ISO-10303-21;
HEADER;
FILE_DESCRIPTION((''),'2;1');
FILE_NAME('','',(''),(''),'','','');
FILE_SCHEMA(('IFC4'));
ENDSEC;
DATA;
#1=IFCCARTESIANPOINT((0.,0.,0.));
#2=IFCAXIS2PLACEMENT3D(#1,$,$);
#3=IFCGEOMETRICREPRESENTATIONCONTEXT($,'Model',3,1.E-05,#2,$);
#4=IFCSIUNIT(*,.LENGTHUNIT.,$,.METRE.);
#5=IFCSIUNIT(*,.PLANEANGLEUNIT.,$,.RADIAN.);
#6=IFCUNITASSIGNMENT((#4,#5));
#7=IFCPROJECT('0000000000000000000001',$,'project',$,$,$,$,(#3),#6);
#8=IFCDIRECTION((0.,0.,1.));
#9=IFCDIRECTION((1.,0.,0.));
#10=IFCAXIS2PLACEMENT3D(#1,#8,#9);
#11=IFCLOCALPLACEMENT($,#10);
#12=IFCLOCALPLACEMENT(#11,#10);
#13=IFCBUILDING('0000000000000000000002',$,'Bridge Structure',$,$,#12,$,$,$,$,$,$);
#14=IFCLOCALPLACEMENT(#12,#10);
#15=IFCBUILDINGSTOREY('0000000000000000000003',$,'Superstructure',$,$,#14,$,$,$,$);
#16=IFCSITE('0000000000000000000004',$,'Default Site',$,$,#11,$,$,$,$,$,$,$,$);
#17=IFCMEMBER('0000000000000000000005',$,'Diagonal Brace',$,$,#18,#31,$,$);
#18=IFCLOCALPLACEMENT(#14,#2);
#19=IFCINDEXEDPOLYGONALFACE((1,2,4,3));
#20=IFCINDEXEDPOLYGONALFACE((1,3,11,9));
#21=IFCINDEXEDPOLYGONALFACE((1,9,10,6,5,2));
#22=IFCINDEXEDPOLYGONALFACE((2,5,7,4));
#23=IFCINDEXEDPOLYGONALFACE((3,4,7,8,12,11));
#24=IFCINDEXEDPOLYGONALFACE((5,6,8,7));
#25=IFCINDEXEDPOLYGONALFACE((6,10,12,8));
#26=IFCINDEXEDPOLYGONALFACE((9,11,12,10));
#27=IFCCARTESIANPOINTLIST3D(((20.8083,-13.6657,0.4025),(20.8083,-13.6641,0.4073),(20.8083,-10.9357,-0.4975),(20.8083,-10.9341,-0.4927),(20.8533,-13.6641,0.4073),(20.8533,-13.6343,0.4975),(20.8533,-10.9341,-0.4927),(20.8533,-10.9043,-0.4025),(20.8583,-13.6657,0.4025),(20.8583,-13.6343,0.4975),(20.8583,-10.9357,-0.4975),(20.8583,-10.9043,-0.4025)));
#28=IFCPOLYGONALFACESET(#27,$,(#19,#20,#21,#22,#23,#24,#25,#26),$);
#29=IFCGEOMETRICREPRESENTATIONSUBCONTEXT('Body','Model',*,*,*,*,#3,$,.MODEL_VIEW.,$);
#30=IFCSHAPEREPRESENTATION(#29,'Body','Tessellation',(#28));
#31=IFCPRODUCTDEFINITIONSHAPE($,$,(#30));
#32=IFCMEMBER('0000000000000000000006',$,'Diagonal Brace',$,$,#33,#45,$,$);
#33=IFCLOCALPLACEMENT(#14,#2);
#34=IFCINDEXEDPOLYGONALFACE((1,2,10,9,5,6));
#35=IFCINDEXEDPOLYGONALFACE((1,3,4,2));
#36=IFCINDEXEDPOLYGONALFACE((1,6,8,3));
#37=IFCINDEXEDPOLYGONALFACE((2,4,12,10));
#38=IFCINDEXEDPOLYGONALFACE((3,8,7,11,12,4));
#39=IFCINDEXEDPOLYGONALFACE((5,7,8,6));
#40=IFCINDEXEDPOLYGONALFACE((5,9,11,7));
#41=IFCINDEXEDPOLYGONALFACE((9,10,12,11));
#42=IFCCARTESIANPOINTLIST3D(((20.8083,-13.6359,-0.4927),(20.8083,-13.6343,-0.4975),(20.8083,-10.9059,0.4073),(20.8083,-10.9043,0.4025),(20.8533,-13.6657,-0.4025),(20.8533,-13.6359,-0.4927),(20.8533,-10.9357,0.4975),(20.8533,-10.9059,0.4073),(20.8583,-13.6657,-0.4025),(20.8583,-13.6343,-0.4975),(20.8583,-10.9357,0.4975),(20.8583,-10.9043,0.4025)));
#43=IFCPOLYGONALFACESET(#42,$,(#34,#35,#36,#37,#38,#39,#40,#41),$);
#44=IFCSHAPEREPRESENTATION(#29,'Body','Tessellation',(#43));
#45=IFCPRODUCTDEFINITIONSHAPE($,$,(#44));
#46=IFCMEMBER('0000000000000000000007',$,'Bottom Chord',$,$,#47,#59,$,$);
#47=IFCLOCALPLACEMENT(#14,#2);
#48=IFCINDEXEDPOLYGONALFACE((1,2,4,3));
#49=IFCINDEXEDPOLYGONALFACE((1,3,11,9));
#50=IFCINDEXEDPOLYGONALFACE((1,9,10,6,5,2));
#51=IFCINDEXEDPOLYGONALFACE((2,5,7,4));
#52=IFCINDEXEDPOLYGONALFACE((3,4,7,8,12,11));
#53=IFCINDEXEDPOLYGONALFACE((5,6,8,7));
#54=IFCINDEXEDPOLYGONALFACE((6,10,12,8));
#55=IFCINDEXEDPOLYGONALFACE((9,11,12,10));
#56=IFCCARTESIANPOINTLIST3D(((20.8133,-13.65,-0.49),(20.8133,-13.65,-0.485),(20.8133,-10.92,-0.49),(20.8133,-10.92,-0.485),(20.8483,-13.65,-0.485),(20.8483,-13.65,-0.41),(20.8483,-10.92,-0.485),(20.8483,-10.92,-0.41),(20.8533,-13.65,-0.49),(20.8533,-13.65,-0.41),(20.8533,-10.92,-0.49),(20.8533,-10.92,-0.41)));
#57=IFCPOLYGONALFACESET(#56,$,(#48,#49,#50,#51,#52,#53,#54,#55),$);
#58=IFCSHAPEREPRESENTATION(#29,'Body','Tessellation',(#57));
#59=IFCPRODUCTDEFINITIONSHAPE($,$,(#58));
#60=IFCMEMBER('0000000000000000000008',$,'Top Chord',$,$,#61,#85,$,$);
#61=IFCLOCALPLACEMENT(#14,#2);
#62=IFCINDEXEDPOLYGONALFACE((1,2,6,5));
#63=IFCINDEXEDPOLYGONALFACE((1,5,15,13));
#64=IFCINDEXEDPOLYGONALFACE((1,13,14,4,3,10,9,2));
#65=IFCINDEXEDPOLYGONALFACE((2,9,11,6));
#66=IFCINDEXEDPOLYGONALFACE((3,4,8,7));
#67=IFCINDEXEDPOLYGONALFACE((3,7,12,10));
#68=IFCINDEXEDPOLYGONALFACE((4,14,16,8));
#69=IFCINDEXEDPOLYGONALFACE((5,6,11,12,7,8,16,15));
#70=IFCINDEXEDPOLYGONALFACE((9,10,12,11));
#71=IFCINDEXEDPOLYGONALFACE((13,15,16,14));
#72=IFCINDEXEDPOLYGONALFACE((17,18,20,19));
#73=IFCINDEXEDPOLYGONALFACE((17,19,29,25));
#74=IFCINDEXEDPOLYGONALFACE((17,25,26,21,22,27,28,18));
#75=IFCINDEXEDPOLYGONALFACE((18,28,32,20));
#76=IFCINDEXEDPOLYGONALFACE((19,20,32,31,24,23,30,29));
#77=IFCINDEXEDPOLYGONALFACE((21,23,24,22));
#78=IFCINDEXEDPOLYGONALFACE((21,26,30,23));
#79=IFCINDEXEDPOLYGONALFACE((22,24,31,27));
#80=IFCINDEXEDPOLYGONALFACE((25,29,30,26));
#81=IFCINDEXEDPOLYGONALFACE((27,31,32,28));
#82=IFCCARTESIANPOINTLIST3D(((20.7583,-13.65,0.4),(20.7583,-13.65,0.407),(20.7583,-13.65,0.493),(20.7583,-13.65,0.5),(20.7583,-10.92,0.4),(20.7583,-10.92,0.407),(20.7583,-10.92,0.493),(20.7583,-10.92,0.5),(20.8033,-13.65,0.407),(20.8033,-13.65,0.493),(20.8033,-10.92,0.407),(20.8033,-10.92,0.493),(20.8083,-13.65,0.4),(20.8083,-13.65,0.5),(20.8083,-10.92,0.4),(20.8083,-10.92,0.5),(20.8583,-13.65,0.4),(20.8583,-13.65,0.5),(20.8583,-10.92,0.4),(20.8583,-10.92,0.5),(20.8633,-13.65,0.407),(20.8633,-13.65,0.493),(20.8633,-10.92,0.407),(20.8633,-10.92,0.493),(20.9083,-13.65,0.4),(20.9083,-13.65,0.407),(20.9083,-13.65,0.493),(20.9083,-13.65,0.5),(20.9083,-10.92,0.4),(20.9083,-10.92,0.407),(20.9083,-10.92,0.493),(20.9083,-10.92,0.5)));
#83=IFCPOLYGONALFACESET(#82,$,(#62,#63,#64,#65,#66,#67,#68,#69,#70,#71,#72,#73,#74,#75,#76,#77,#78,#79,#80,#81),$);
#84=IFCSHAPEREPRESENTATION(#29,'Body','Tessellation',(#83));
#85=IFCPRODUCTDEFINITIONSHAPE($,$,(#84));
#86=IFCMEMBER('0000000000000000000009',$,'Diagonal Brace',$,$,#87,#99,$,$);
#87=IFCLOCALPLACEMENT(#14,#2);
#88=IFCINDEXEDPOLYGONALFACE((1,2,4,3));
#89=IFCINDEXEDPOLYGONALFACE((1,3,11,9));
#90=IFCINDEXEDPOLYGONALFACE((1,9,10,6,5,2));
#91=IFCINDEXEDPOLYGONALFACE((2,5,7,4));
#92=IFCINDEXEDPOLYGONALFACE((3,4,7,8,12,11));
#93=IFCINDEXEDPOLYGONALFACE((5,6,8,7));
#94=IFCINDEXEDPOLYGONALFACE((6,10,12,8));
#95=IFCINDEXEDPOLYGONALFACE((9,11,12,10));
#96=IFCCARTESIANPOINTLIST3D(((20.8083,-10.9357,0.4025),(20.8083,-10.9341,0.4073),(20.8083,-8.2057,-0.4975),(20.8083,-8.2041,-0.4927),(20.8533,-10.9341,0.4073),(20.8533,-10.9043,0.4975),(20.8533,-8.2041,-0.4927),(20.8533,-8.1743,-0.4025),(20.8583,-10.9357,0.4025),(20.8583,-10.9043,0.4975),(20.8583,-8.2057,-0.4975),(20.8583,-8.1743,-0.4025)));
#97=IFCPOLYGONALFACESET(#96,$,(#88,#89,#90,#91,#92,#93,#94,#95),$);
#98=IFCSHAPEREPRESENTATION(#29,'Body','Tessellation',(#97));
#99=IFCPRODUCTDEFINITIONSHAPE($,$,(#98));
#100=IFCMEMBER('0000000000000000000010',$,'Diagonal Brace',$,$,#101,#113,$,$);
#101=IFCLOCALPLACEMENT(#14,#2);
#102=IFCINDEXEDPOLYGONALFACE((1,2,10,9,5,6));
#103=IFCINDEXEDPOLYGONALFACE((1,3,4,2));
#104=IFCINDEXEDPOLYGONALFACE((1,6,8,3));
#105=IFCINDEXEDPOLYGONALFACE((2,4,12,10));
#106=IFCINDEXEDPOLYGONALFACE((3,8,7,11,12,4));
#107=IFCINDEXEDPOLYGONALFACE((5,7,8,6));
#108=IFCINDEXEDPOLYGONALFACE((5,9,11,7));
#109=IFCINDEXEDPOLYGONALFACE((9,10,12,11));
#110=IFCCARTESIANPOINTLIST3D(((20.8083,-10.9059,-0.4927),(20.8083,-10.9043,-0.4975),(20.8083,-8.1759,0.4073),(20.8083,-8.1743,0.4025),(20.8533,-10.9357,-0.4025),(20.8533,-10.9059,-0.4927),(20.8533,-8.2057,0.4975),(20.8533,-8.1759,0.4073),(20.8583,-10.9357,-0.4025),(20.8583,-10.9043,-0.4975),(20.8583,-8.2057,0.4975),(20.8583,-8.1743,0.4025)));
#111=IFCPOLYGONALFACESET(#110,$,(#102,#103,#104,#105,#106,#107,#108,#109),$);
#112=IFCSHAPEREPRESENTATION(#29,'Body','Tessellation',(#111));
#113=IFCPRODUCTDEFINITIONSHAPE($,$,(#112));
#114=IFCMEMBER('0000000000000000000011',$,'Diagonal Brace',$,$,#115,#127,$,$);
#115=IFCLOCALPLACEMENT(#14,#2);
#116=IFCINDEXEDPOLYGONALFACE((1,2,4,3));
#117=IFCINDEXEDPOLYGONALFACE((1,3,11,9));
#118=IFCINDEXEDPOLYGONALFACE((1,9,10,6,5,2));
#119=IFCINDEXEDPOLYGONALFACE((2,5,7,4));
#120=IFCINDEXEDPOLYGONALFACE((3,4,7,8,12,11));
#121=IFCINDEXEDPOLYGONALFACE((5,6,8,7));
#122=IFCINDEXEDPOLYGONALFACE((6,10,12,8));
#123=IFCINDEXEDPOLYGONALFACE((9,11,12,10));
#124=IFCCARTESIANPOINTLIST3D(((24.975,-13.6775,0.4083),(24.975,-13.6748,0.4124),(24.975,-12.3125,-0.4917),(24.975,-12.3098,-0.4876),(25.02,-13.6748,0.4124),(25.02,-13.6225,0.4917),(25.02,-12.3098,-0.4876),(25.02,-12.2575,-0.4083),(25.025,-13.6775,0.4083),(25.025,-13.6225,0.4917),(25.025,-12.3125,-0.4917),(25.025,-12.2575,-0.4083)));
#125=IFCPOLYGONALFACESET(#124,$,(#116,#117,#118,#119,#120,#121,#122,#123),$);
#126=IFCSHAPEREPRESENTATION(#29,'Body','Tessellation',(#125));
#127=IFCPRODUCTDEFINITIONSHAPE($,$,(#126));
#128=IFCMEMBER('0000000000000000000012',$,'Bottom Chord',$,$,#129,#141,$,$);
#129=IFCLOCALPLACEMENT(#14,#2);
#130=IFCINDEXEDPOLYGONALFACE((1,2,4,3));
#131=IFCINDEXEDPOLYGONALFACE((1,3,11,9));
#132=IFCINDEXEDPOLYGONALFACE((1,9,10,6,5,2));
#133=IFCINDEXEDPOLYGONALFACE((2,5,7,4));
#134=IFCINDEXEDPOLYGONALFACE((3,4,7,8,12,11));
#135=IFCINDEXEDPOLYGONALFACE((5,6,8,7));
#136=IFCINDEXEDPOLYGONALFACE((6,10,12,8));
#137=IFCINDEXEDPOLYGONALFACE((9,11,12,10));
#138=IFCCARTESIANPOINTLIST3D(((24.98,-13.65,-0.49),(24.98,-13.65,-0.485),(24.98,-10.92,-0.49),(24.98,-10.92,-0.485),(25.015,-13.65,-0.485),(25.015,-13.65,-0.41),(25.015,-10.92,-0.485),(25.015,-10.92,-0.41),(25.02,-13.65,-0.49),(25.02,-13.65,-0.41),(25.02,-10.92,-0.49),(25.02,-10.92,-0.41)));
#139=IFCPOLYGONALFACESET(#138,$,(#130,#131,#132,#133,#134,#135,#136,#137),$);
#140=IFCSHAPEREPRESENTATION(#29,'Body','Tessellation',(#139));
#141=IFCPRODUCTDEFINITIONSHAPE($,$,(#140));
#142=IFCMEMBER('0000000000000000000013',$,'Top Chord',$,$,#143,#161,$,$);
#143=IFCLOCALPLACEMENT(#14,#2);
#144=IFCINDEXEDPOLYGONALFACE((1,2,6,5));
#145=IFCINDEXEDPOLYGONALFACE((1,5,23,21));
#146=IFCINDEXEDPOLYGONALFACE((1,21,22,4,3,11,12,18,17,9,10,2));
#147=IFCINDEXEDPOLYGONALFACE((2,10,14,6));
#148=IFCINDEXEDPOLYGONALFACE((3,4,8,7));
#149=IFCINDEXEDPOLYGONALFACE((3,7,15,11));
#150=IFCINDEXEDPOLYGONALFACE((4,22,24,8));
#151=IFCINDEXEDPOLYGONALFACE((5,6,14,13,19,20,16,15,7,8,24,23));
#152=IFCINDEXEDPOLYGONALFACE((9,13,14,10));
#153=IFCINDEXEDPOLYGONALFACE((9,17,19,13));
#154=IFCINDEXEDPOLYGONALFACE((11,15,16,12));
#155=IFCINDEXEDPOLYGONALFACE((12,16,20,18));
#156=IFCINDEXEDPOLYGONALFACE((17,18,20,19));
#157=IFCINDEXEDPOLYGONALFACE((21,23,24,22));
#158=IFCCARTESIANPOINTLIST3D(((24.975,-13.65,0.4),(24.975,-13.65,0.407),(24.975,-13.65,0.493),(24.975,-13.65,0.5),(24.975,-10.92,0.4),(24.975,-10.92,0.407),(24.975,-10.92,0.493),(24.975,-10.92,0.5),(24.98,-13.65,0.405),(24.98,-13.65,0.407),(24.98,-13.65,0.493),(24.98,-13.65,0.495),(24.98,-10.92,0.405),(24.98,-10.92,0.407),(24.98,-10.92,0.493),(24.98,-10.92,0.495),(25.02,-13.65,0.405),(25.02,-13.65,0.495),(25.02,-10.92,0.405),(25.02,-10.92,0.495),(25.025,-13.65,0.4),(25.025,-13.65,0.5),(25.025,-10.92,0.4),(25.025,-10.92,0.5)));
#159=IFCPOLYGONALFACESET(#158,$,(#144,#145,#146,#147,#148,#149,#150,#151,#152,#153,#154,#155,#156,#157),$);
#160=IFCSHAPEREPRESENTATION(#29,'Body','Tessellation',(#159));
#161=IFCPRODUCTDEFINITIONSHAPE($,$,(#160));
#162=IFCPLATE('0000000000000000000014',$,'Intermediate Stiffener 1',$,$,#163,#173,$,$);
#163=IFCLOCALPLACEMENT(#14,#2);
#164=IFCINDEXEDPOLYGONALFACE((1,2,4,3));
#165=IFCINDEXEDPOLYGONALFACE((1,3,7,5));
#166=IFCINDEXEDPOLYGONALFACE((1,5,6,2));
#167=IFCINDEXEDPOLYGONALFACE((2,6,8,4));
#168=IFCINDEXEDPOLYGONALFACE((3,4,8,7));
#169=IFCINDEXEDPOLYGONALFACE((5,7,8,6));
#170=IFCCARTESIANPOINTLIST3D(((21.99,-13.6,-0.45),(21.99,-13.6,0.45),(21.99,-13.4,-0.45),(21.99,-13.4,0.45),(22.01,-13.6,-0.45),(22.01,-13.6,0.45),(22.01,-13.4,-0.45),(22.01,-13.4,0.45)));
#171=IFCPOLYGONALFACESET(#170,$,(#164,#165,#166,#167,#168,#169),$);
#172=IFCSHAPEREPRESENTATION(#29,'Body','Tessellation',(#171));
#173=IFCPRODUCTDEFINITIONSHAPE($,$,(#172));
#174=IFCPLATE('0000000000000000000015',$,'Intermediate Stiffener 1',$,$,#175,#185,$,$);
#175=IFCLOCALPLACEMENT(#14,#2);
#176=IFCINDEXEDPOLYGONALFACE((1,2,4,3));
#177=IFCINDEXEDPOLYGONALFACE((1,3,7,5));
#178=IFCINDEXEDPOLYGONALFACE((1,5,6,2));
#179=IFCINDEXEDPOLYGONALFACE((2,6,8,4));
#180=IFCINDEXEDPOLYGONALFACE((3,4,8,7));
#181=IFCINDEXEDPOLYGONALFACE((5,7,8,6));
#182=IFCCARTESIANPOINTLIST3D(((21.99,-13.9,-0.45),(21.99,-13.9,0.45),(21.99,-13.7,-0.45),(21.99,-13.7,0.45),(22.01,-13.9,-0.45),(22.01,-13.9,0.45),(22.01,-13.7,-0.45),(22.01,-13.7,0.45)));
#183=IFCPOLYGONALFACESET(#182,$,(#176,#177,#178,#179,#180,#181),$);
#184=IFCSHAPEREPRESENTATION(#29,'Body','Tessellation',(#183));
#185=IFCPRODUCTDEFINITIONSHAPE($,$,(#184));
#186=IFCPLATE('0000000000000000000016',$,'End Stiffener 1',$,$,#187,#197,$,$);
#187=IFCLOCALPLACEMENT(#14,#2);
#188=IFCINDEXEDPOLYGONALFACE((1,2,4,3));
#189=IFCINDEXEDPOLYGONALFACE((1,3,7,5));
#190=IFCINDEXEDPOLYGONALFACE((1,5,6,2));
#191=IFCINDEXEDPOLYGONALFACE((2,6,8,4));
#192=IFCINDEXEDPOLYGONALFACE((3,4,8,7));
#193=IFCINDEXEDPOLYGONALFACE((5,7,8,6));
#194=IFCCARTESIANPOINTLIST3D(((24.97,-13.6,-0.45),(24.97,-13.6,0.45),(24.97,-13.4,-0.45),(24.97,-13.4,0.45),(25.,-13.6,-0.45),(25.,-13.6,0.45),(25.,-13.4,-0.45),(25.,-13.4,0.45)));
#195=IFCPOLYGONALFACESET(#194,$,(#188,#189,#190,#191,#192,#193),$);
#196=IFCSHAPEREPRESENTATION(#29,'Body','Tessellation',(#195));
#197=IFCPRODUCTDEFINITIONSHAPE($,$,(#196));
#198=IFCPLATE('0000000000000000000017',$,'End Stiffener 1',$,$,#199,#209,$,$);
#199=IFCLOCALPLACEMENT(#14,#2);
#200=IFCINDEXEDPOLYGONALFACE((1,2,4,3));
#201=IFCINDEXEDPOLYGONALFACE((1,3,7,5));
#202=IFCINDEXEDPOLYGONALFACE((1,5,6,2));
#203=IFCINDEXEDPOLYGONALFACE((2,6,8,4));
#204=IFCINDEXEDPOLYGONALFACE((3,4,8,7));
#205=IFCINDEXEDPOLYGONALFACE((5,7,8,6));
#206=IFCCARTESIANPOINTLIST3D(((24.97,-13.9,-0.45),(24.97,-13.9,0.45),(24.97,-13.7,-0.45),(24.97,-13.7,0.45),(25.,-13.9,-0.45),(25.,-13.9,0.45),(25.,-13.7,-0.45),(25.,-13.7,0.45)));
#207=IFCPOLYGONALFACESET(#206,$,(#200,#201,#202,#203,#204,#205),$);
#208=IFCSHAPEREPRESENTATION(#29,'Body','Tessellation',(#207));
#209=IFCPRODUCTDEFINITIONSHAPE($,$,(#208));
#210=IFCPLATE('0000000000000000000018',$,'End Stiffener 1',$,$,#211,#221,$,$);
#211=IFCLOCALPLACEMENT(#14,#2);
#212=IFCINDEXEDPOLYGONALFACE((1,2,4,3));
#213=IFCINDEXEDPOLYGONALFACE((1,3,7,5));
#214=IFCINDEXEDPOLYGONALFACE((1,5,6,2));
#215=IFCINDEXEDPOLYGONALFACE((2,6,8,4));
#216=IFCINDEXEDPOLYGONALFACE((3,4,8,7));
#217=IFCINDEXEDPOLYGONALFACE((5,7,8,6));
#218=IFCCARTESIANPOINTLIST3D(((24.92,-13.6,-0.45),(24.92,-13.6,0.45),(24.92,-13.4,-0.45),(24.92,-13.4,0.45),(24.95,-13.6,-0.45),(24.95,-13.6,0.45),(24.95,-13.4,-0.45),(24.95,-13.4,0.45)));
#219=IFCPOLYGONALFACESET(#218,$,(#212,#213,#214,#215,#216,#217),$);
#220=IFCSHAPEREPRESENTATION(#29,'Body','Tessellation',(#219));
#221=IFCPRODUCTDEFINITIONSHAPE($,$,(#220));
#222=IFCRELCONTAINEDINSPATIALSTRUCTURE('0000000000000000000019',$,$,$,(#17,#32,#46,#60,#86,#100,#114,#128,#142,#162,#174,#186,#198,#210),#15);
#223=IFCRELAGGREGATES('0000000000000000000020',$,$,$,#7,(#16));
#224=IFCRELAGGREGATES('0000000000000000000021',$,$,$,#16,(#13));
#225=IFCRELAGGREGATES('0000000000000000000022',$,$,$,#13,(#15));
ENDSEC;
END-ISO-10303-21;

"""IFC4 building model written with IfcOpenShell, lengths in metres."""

from ifc_helpers import new_model, si_unit, frame, origin, origin_with_axes, origin_2d_with_axis, place, context, subcontext, project, spatial, polyline, rectangle, l_section, c_section, outline, composite_profile, extrude, element, save


model = new_model("IFC4")

# Units and contexts
model_context = context("Model", 3, precision=1e-05, world=origin())
body_context = subcontext(model_context, "Body", "Model", "MODEL_VIEW")
ifc_project = project(units=[si_unit("LENGTHUNIT", "METRE"), si_unit("PLANEANGLEUNIT", "RADIAN")], contexts=[model_context])

# Site, building, storey
site_placement = place(None, origin_with_axes())
site = spatial("IfcSite", under=ifc_project, at=site_placement, Name="Default Site")
building_placement = place(site_placement, origin_with_axes())
building = spatial("IfcBuilding", under=site, at=building_placement, Name="Bridge Structure")
storey_placement = place(building_placement, origin_with_axes())
storey = spatial("IfcBuildingStorey", under=building, at=storey_placement, Name="Superstructure")

# Members
for number, where, z_axis, x_axis, name in (
    (1, (20.8333, -13.65, 0.45), (0.0, 0.949722, -0.313095), (-1.0, 0.0, 0.0), "Diagonal Brace"),
    (2, (20.8333, -13.65, -0.45), (0.0, 0.949722, 0.313095), (-1.0, 0.0, 0.0), "Diagonal Brace"),
):
    element("IfcMember", number, at=place(storey_placement, frame(where, z_axis=z_axis, x_axis=x_axis)), inside=storey, Name=name, context=body_context, shape_type="SweptSolid", body=[
        extrude(l_section(Depth=0.1, Width=0.05, Thickness=0.005, at=origin_2d_with_axis()), origin_with_axes(), (0.0, 0.0, 1.0), 2.8745),
    ])
member_1_placement = place(storey_placement, frame((20.8333, -13.65, -0.45), z_axis=(0.0, 1.0, 0.0), x_axis=(-1.0, 0.0, 0.0)))
element("IfcMember", 3, at=member_1_placement, inside=storey, Name="Bottom Chord", context=body_context, shape_type="SweptSolid", body=[
    extrude(l_section(Depth=0.08, Width=0.04, Thickness=0.005, at=origin_2d_with_axis()), origin_with_axes(), (0.0, 0.0, 1.0), 2.73),
])
member_2_placement = place(storey_placement, frame((20.8333, -13.65, 0.45), z_axis=(0.0, 1.0, 0.0), x_axis=(-1.0, 0.0, 0.0)))
element("IfcMember", 4, at=member_2_placement, inside=storey, Name="Top Chord", context=body_context, shape_type="SweptSolid", body=[
    extrude(composite_profile([outline(polyline([(-0.025, -0.05), (-0.025, 0.05), (-0.075, 0.05), (-0.075, 0.043), (-0.03, 0.043), (-0.03, -0.043), (-0.075, -0.043), (-0.075, -0.05), (-0.025, -0.05)])), outline(polyline([(0.025, -0.05), (0.075, -0.05), (0.075, -0.043), (0.03, -0.043), (0.03, 0.043), (0.075, 0.043), (0.075, 0.05), (0.025, 0.05), (0.025, -0.05)]))]), origin_with_axes(), (0.0, 0.0, 1.0), 2.73),
])
for number, where, z_axis, x_axis, name in (
    (5, (20.8333, -10.92, 0.45), (0.0, 0.949722, -0.313095), (-1.0, 0.0, 0.0), "Diagonal Brace"),
    (6, (20.8333, -10.92, -0.45), (0.0, 0.949722, 0.313095), (-1.0, 0.0, 0.0), "Diagonal Brace"),
):
    element("IfcMember", number, at=place(storey_placement, frame(where, z_axis=z_axis, x_axis=x_axis)), inside=storey, Name=name, context=body_context, shape_type="SweptSolid", body=[
        extrude(l_section(Depth=0.1, Width=0.05, Thickness=0.005, at=origin_2d_with_axis()), origin_with_axes(), (0.0, 0.0, 1.0), 2.8745),
    ])
member_3_placement = place(storey_placement, frame((25.0, -13.65, 0.45), z_axis=(0.0, 0.834862, -0.550459), x_axis=(-1.0, 0.0, 0.0)))
element("IfcMember", 7, at=member_3_placement, inside=storey, Name="Diagonal Brace", context=body_context, shape_type="SweptSolid", body=[
    extrude(l_section(Depth=0.1, Width=0.05, Thickness=0.005, at=origin_2d_with_axis()), origin_with_axes(), (0.0, 0.0, 1.0), 1.635),
])
member_4_placement = place(storey_placement, frame((25.0, -13.65, -0.45), z_axis=(0.0, 1.0, 0.0), x_axis=(-1.0, 0.0, 0.0)))
element("IfcMember", 8, at=member_4_placement, inside=storey, Name="Bottom Chord", context=body_context, shape_type="SweptSolid", body=[
    extrude(l_section(Depth=0.08, Width=0.04, Thickness=0.005, at=origin_2d_with_axis()), origin_with_axes(), (0.0, 0.0, 1.0), 2.73),
])
member_5_placement = place(storey_placement, frame((25.0, -13.65, 0.45), z_axis=(0.0, 1.0, 0.0), x_axis=(-1.0, 0.0, 0.0)))
element("IfcMember", 9, at=member_5_placement, inside=storey, Name="Top Chord", context=body_context, shape_type="SweptSolid", body=[
    extrude(c_section(Depth=0.1, Width=0.05, WallThickness=0.005, Girth=0.007, at=origin_2d_with_axis()), origin_with_axes(), (0.0, 0.0, 1.0), 2.73),
])

# Plates
for number, where, z_axis, x_axis, name in (
    (10, (22.0, -13.5, -0.45), (0.0, 0.0, 1.0), (1.0, 0.0, 0.0), "Intermediate Stiffener 1"),
    (11, (22.0, -13.8, -0.45), (0.0, 0.0, 1.0), (1.0, 0.0, 0.0), "Intermediate Stiffener 1"),
):
    element("IfcPlate", number, at=place(storey_placement, frame(where, z_axis=z_axis, x_axis=x_axis)), inside=storey, Name=name, context=body_context, shape_type="SweptSolid", body=[
        extrude(rectangle(XDim=0.02, YDim=0.2, at=origin_2d_with_axis()), origin_with_axes(), (0.0, 0.0, 1.0), 0.9),
    ])
for number, where, z_axis, x_axis, name in (
    (12, (24.985, -13.5, -0.45), (0.0, 0.0, 1.0), (1.0, 0.0, 0.0), "End Stiffener 1"),
    (13, (24.985, -13.8, -0.45), (0.0, 0.0, 1.0), (1.0, 0.0, 0.0), "End Stiffener 1"),
    (14, (24.935, -13.5, -0.45), (0.0, 0.0, 1.0), (1.0, 0.0, 0.0), "End Stiffener 1"),
):
    element("IfcPlate", number, at=place(storey_placement, frame(where, z_axis=z_axis, x_axis=x_axis)), inside=storey, Name=name, context=body_context, shape_type="SweptSolid", body=[
        extrude(rectangle(XDim=0.03, YDim=0.2, at=origin_2d_with_axis()), origin_with_axes(), (0.0, 0.0, 1.0), 0.9),
    ])

save(model, "model.ifc")
